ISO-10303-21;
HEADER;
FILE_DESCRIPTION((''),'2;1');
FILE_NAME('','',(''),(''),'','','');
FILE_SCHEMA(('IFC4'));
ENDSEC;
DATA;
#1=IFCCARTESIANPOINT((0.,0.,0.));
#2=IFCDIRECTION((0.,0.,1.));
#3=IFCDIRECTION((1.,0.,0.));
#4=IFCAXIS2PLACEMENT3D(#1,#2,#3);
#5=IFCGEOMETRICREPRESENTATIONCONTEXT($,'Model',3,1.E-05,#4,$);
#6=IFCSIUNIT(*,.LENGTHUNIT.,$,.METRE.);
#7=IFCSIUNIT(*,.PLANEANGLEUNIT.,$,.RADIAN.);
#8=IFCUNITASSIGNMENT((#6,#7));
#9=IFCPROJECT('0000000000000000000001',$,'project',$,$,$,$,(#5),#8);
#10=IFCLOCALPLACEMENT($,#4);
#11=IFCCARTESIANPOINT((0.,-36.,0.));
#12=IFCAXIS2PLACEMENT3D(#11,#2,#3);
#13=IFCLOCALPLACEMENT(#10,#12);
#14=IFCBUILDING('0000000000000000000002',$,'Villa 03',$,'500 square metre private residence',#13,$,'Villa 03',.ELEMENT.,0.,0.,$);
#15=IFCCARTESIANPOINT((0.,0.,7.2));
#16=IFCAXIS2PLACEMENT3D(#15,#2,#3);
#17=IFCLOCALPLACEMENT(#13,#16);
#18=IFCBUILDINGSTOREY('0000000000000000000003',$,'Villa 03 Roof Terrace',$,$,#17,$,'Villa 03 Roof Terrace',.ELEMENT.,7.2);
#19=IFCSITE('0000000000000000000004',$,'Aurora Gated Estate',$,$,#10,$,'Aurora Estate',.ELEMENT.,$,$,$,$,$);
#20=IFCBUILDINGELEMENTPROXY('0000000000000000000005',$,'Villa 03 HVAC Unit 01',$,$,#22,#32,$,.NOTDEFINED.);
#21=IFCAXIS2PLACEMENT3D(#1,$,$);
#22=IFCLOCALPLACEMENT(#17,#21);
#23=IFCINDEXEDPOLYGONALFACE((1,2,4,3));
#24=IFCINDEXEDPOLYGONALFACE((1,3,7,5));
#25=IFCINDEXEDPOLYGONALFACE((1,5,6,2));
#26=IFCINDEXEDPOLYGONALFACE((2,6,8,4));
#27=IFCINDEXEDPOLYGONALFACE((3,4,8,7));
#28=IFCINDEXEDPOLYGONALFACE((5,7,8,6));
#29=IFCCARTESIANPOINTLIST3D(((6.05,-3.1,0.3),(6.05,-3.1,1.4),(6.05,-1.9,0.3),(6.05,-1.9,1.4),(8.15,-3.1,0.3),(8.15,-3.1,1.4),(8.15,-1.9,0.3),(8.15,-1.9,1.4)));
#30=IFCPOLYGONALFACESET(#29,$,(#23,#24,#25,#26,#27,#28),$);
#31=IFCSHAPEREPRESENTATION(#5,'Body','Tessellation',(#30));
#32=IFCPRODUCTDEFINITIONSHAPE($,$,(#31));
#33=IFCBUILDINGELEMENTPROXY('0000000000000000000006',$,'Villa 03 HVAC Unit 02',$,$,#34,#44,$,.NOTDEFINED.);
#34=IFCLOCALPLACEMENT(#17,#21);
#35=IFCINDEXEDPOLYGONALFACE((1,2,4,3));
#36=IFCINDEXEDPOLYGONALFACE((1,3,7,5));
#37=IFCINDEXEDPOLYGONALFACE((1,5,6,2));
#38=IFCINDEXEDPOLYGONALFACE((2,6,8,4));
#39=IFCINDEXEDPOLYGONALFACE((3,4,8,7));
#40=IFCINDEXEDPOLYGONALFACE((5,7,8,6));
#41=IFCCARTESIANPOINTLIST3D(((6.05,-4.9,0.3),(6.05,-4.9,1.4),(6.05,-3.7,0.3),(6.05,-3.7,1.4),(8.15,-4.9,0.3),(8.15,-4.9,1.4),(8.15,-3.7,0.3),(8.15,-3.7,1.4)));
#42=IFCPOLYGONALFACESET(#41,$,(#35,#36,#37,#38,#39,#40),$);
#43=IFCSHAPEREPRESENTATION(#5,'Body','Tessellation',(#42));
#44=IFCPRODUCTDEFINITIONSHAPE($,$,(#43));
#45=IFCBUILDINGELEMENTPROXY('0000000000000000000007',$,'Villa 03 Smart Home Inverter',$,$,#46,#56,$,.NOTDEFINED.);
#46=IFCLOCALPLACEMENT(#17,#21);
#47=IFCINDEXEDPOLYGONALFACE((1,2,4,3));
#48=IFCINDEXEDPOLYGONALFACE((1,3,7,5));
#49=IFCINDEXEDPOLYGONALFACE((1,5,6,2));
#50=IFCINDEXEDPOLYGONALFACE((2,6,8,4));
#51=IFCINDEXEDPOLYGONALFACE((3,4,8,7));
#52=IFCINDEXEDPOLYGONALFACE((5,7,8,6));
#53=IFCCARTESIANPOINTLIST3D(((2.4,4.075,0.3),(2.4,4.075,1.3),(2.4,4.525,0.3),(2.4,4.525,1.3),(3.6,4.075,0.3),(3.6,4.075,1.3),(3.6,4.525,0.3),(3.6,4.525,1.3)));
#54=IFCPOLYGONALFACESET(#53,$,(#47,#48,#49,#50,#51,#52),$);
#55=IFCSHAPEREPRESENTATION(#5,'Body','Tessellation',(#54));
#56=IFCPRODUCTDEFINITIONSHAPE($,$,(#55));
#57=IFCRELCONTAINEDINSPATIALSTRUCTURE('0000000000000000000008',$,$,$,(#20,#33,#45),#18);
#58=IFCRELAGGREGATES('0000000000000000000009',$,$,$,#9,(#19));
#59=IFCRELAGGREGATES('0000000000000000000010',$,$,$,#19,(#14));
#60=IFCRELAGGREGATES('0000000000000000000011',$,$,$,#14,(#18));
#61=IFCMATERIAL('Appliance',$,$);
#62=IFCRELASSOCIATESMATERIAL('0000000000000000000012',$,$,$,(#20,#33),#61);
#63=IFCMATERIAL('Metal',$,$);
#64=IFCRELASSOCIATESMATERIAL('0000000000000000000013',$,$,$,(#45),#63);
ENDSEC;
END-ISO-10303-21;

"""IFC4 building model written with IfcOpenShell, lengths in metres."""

from ifc_helpers import new_model, si_unit, frame, origin_with_axes, origin_2d_with_axis, place, context, project, spatial, rectangle, extrude, material, element, save


model = new_model("IFC4")

# Units and contexts
model_context = context("Model", 3, precision=1e-05, world=origin_with_axes())
ifc_project = project(units=[si_unit("LENGTHUNIT", "METRE"), si_unit("PLANEANGLEUNIT", "RADIAN")], contexts=[model_context])

# Site, building, storey
site_placement = place(None, origin_with_axes())
site = spatial("IfcSite", under=ifc_project, at=site_placement, Name="Aurora Gated Estate", LongName="Aurora Estate", CompositionType="ELEMENT")
building_placement = place(site_placement, frame((0.0, -36.0, 0.0), z_axis=(0.0, 0.0, 1.0), x_axis=(1.0, 0.0, 0.0)))
building = spatial("IfcBuilding", under=site, at=building_placement, Name="Villa 03", ObjectType="500 square metre private residence", LongName="Villa 03", CompositionType="ELEMENT", ElevationOfRefHeight=0.0, ElevationOfTerrain=0.0)
storey_placement = place(building_placement, frame((0.0, 0.0, 7.2), z_axis=(0.0, 0.0, 1.0), x_axis=(1.0, 0.0, 0.0)))
storey = spatial("IfcBuildingStorey", under=building, at=storey_placement, Name="Villa 03 Roof Terrace", LongName="Villa 03 Roof Terrace", CompositionType="ELEMENT", Elevation=7.2)

# Building element proxies
ifc_material_1 = material(Name="Metal")
ifc_material_2 = material(Name="Appliance")
for number, where, z_axis, x_axis, name in (
    (1, (7.1, -2.5, 0.3), (0.0, 0.0, 1.0), (1.0, 0.0, 0.0), "Villa 03 HVAC Unit 01"),
    (2, (7.1, -4.3, 0.3), (0.0, 0.0, 1.0), (1.0, 0.0, 0.0), "Villa 03 HVAC Unit 02"),
):
    element("IfcBuildingElementProxy", number, at=place(storey_placement, frame(where, z_axis=z_axis, x_axis=x_axis)), inside=storey, material=ifc_material_2, Name=name, PredefinedType="NOTDEFINED", context=model_context, shape_type="SweptSolid", body=[
        extrude(rectangle(XDim=2.1, YDim=1.2, at=origin_2d_with_axis()), origin_with_axes(), (0.0, 0.0, 1.0), 1.1),
    ])
proxy_1_placement = place(storey_placement, frame((3.0, 4.3, 0.3), z_axis=(0.0, 0.0, 1.0), x_axis=(1.0, 0.0, 0.0)))
element("IfcBuildingElementProxy", 3, at=proxy_1_placement, inside=storey, material=ifc_material_1, Name="Villa 03 Smart Home Inverter", PredefinedType="NOTDEFINED", context=model_context, shape_type="SweptSolid", body=[
    extrude(rectangle(XDim=1.2, YDim=0.45, at=origin_2d_with_axis()), origin_with_axes(), (0.0, 0.0, 1.0), 1.0),
])

save(model, "model.ifc")
